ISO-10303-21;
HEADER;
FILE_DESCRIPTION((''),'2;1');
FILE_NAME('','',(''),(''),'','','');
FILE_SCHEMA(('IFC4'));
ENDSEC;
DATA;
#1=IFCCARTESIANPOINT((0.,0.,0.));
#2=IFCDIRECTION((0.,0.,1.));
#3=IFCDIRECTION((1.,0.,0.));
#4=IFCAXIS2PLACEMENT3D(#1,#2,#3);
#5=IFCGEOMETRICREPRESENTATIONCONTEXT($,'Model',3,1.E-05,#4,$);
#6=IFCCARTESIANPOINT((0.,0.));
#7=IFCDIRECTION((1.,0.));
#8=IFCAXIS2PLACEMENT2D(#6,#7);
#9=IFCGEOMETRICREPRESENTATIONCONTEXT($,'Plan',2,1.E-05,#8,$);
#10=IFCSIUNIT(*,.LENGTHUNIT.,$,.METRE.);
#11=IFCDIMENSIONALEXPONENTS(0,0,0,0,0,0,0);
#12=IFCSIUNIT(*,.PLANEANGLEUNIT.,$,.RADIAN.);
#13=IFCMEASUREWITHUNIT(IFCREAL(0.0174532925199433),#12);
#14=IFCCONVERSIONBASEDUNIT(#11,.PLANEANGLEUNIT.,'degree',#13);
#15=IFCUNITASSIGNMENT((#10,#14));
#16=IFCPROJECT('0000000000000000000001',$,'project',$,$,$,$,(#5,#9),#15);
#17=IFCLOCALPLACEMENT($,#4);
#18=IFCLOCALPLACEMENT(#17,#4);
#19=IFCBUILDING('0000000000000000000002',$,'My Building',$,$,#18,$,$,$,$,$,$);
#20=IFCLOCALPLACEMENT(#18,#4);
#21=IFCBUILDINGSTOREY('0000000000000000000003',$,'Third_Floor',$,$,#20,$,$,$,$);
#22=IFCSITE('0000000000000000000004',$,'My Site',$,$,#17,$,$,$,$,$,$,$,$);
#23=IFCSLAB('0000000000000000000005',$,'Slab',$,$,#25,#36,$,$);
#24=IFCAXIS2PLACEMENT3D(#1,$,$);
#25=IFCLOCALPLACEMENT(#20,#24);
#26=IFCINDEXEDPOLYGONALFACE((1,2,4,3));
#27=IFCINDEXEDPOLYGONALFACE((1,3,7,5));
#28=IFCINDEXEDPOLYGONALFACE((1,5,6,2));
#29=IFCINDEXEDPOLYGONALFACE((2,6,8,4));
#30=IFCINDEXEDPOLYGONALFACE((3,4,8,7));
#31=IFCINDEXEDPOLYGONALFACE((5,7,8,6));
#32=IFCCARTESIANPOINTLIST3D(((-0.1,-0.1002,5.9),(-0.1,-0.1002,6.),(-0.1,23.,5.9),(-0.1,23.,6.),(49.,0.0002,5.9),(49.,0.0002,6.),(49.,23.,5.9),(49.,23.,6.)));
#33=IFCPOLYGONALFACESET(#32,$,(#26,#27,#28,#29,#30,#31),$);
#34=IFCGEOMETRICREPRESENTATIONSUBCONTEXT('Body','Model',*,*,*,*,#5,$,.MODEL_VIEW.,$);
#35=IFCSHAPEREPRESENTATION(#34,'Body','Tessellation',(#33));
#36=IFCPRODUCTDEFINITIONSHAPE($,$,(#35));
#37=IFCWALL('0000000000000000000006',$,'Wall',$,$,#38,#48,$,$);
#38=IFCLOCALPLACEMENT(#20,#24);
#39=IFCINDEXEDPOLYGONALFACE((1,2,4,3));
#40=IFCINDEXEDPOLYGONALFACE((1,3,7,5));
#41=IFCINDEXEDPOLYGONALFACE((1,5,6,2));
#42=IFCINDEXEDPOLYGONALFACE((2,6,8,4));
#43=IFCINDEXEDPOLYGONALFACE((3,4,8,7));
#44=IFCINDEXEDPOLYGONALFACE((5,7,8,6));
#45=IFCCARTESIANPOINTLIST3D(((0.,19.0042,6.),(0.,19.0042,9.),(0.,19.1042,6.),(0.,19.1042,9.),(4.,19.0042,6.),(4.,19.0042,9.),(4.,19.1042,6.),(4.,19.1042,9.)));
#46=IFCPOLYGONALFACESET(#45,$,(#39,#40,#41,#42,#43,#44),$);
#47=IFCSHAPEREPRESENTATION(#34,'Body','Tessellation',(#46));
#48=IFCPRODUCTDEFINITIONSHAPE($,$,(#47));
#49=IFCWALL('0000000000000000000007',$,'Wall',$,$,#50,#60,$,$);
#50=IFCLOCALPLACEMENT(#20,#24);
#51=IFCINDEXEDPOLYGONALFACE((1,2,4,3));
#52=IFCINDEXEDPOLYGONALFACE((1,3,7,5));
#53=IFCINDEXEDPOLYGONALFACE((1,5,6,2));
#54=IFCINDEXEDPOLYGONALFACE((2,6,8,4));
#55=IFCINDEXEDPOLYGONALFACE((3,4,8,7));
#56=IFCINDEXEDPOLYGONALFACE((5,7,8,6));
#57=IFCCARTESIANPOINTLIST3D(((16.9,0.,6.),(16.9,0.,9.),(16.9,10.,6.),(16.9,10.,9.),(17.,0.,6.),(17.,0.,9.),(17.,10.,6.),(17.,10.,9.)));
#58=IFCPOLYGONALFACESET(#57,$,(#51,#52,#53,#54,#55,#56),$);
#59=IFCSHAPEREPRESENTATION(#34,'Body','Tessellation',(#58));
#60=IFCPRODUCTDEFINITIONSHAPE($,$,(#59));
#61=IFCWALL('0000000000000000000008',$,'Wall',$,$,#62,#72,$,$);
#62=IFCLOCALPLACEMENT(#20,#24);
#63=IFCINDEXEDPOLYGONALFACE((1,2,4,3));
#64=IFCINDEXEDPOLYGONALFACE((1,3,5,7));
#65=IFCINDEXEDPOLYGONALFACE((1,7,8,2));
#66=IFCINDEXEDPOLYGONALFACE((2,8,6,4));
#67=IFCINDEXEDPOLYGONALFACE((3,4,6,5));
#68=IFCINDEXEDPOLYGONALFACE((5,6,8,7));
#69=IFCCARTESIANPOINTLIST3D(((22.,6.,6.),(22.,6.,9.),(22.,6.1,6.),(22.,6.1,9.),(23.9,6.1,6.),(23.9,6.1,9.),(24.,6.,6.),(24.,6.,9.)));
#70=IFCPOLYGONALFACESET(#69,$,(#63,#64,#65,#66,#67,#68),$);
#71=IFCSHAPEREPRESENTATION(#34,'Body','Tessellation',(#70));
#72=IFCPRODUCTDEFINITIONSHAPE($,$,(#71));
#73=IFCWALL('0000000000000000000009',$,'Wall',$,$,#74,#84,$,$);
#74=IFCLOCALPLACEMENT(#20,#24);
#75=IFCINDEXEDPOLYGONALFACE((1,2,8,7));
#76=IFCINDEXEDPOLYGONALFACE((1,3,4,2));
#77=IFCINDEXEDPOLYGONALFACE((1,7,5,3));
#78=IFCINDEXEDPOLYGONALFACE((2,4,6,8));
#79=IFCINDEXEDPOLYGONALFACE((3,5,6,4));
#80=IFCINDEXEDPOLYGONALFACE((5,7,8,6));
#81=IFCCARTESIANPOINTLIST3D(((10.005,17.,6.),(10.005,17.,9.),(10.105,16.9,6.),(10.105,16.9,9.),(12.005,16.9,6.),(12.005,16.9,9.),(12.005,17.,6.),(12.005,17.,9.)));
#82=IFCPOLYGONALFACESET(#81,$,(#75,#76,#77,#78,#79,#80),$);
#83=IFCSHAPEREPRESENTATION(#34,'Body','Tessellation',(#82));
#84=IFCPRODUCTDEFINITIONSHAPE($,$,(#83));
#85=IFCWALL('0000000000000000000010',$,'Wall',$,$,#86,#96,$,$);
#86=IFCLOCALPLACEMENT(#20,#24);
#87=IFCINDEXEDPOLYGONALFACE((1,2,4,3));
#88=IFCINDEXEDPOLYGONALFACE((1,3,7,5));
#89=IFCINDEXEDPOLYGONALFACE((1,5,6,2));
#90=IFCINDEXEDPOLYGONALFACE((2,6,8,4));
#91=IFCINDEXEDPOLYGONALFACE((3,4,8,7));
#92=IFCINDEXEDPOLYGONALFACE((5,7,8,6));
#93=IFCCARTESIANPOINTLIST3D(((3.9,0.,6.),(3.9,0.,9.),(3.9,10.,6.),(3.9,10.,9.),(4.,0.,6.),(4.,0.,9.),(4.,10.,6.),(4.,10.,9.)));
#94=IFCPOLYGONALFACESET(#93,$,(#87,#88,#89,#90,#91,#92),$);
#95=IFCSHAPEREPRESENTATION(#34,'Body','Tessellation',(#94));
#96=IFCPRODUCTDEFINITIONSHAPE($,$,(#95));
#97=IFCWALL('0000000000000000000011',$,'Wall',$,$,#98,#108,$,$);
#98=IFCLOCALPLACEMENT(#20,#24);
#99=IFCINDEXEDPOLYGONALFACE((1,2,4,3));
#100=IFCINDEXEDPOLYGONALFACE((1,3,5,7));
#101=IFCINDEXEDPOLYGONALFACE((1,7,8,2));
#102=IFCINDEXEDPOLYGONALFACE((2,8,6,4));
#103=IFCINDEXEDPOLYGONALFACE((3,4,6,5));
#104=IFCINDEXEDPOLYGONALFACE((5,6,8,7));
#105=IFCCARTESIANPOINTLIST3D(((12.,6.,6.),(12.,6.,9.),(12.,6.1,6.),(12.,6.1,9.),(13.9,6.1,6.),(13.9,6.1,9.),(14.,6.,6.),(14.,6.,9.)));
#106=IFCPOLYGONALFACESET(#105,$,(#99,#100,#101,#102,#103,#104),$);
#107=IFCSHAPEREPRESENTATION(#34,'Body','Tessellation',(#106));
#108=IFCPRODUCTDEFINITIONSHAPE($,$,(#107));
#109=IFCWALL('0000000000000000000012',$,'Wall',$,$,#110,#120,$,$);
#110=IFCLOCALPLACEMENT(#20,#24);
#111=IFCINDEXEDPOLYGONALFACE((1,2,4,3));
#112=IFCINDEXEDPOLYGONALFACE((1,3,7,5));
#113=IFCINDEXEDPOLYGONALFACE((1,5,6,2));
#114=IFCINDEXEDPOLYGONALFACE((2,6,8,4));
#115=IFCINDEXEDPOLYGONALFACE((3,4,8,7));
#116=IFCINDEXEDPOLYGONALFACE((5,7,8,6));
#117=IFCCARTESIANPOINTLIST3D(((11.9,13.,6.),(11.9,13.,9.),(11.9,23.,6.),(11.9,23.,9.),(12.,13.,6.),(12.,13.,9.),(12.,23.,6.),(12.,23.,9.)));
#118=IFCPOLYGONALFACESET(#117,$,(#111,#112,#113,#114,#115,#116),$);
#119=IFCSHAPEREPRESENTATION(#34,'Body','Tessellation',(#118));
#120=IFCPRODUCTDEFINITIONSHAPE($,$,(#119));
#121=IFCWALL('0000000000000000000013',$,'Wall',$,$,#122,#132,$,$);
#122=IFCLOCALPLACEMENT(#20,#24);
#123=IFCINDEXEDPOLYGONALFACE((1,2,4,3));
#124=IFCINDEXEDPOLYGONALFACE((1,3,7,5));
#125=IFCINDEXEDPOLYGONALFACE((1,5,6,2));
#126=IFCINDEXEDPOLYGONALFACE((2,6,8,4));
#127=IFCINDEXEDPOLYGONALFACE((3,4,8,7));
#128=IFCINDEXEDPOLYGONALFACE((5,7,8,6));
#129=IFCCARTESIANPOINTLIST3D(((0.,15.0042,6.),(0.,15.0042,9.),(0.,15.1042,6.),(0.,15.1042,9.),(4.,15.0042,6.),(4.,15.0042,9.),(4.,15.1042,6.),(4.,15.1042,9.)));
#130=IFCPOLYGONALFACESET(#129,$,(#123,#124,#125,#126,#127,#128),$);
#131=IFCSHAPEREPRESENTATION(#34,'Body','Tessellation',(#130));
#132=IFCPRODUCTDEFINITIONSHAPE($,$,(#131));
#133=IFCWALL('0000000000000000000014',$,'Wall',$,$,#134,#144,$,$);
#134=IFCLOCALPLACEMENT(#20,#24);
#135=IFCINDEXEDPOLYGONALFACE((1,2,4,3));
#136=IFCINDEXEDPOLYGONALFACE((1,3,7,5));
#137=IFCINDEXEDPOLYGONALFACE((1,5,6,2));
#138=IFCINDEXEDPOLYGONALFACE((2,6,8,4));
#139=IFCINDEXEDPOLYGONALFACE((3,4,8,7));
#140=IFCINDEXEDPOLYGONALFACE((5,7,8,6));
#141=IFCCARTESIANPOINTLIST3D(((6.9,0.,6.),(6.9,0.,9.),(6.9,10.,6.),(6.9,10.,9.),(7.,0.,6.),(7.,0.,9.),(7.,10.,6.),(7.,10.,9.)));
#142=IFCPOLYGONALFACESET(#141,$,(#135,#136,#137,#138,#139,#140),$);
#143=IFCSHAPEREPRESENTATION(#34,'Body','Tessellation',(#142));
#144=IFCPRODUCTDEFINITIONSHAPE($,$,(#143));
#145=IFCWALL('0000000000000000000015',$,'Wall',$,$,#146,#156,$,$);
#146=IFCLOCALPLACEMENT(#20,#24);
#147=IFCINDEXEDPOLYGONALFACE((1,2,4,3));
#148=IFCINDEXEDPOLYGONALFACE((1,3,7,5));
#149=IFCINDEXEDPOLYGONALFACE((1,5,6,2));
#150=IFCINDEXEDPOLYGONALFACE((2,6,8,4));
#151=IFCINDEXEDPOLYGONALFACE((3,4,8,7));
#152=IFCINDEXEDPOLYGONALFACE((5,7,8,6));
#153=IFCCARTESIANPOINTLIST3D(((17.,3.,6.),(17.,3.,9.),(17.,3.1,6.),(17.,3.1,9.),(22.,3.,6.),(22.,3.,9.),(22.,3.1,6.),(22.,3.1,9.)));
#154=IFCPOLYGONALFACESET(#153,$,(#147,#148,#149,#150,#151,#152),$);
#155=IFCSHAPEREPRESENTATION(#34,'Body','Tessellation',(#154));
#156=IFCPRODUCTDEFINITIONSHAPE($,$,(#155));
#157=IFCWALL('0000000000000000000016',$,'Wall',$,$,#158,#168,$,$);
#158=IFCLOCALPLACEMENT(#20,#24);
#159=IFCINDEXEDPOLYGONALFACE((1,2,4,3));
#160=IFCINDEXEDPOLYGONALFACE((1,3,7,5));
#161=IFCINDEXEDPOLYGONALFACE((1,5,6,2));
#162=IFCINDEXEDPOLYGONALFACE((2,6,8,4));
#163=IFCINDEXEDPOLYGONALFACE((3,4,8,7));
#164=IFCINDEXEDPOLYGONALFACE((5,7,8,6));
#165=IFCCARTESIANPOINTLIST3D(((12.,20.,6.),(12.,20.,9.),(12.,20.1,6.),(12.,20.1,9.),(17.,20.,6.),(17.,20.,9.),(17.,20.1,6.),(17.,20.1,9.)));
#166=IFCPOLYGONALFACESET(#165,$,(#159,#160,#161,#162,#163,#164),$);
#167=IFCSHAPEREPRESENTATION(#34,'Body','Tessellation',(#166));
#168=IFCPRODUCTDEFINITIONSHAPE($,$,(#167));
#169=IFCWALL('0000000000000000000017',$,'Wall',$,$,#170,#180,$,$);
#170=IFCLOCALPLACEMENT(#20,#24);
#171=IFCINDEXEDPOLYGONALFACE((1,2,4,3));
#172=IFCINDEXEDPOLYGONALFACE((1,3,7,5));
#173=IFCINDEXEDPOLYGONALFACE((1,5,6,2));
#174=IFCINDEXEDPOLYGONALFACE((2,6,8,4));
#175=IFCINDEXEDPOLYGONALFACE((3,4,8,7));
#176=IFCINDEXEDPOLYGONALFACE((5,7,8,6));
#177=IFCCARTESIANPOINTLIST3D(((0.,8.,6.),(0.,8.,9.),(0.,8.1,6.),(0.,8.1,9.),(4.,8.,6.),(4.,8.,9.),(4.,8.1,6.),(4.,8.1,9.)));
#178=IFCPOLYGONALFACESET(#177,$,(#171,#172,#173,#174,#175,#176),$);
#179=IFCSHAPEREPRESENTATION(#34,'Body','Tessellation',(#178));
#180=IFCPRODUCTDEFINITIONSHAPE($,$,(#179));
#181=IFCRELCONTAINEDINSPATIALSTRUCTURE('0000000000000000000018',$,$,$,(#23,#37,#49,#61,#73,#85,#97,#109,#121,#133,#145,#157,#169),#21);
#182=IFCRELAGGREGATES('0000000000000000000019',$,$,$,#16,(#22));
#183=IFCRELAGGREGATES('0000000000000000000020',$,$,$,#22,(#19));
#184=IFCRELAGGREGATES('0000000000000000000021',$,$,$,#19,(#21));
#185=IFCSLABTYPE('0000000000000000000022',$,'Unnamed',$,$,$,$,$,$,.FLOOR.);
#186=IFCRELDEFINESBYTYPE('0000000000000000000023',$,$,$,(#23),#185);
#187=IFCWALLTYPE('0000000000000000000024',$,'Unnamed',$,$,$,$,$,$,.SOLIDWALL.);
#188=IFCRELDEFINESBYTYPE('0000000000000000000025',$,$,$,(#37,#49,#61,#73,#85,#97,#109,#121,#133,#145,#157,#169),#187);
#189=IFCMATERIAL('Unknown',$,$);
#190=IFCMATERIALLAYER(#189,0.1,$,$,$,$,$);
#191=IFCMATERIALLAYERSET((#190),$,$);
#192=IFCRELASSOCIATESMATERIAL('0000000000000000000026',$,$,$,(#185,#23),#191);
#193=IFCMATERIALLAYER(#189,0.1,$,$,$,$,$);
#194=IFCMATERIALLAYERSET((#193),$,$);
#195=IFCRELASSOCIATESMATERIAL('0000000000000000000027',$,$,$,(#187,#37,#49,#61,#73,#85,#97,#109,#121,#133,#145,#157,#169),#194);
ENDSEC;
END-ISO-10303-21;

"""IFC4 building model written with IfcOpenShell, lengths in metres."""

from ifc_helpers import new_model, entity, si_unit, converted_unit, frame, origin_with_axes, origin_2d_with_axis, place, context, subcontext, project, spatial, line, indexed_curve, outline, extrude, material, layer, layer_set, layer_usage, type_object, element, save


model = new_model("IFC4")

# Units and contexts
model_context = context("Model", 3, precision=1e-05, world=origin_with_axes())
plan_context = context("Plan", 2, precision=1e-05, world=origin_2d_with_axis())
body_context = subcontext(model_context, "Body", "Model", "MODEL_VIEW")
ifc_project = project(units=[si_unit("LENGTHUNIT", "METRE"), converted_unit("PLANEANGLEUNIT", "degree", entity("IfcReal", 0.0174532925199433), si_unit("PLANEANGLEUNIT", "RADIAN"), dimensions=[0, 0, 0, 0, 0, 0, 0])], contexts=[model_context, plan_context])

# Site, building, storey
site_placement = place(None, origin_with_axes())
site = spatial("IfcSite", under=ifc_project, at=site_placement, Name="My Site")
building_placement = place(site_placement, origin_with_axes())
building = spatial("IfcBuilding", under=site, at=building_placement, Name="My Building")
storey_placement = place(building_placement, origin_with_axes())
storey = spatial("IfcBuildingStorey", under=building, at=storey_placement, Name="Third_Floor")

# Slab
ifc_material = material(Name="Unknown")
ifc_layer_1 = layer(ifc_material, 0.1)
ifc_layer_set_1 = layer_set([ifc_layer_1])
ifc_layer_usage_1 = layer_usage(ifc_layer_set_1, "AXIS3", "POSITIVE", -0.1)
slab_type = type_object("IfcSlabType", Name="Unnamed", PredefinedType="FLOOR", material=ifc_layer_set_1)
slab_placement = place(storey_placement, frame((-0.1, 23.0, 6.0), z_axis=(0.0, 0.0, 1.0), x_axis=(1.0, 0.0, 0.0)))
element("IfcSlab", 1, at=slab_placement, inside=storey, type_object=slab_type, material=ifc_layer_usage_1, Name="Slab", context=body_context, shape_type="SweptSolid", body=[
    extrude(outline(indexed_curve([(0.0, -23.1002), (49.1, -22.9998), (49.1, 0.0), (0.0, 0.0), (0.0, -23.1002)])), frame((0.0, 0.0, -0.1), z_axis=(0.0, 0.0, 1.0), x_axis=(1.0, 0.0, 0.0)), (0.0, 0.0, 1.0), 0.1),
])

# Walls
ifc_layer_2 = layer(ifc_material, 0.1)
ifc_layer_set_2 = layer_set([ifc_layer_2])
ifc_layer_usage_2 = layer_usage(ifc_layer_set_2, "AXIS2", "POSITIVE", 0.0)
wall_type = type_object("IfcWallType", Name="Unnamed", PredefinedType="SOLIDWALL", material=ifc_layer_set_2)
wall_1_placement = place(storey_placement, frame((0.0, 19.0042, 6.0), z_axis=(0.0, 0.0, 1.0), x_axis=(1.0, 0.0, 0.0)))
element("IfcWall", 2, at=wall_1_placement, inside=storey, type_object=wall_type, material=ifc_layer_usage_2, Name="Wall", context=body_context, shape_type="SweptSolid", body=[
    extrude(outline(indexed_curve([(0.0, 0.0), (0.0, 0.1), (4.0, 0.1), (4.0, 0.0)], segments=[line(1, 2, 3, 4, 1)])), origin_with_axes(), (0.0, 0.0, 1.0), 3.0),
])
ifc_layer_usage_3 = layer_usage(ifc_layer_set_2, "AXIS2", "POSITIVE", 0.0)
wall_2_placement = place(storey_placement, frame((16.9, 10.0, 6.0), z_axis=(0.0, 0.0, 1.0), x_axis=(0.0, -1.0, 0.0)))
element("IfcWall", 3, at=wall_2_placement, inside=storey, type_object=wall_type, material=ifc_layer_usage_3, Name="Wall", context=body_context, shape_type="SweptSolid", body=[
    extrude(outline(indexed_curve([(0.0, 0.0), (0.0, 0.1), (10.0, 0.1), (10.0, 0.0)], segments=[line(1, 2, 3, 4, 1)])), origin_with_axes(), (0.0, 0.0, 1.0), 3.0),
])
ifc_layer_usage_4 = layer_usage(ifc_layer_set_2, "AXIS2", "POSITIVE", 0.0)
wall_3_placement = place(storey_placement, frame((22.0, 6.0, 6.0), z_axis=(0.0, 0.0, 1.0), x_axis=(1.0, 0.0, 0.0)))
element("IfcWall", 4, at=wall_3_placement, inside=storey, type_object=wall_type, material=ifc_layer_usage_4, Name="Wall", context=body_context, shape_type="SweptSolid", body=[
    extrude(outline(indexed_curve([(0.0, 0.0), (0.0, 0.1), (1.9, 0.1), (2.0, 0.0)], segments=[line(1, 2, 3, 4, 1)])), origin_with_axes(), (0.0, 0.0, 1.0), 3.0),
])
ifc_layer_usage_5 = layer_usage(ifc_layer_set_2, "AXIS2", "POSITIVE", 0.0)
wall_4_placement = place(storey_placement, frame((12.005, 17.0, 6.0), z_axis=(0.0, 0.0, 1.0), x_axis=(-1.0, 0.0, 0.0)))
element("IfcWall", 5, at=wall_4_placement, inside=storey, type_object=wall_type, material=ifc_layer_usage_5, Name="Wall", context=body_context, shape_type="SweptSolid", body=[
    extrude(outline(indexed_curve([(0.0, 0.0), (0.0, 0.1), (1.9, 0.1), (2.0, 0.0)], segments=[line(1, 2, 3, 4, 1)])), origin_with_axes(), (0.0, 0.0, 1.0), 3.0),
])
ifc_layer_usage_6 = layer_usage(ifc_layer_set_2, "AXIS2", "POSITIVE", 0.0)
wall_5_placement = place(storey_placement, frame((3.9, 10.0, 6.0), z_axis=(0.0, 0.0, 1.0), x_axis=(0.0, -1.0, 0.0)))
element("IfcWall", 6, at=wall_5_placement, inside=storey, type_object=wall_type, material=ifc_layer_usage_6, Name="Wall", context=body_context, shape_type="SweptSolid", body=[
    extrude(outline(indexed_curve([(0.0, 0.0), (0.0, 0.1), (10.0, 0.1), (10.0, 0.0)], segments=[line(1, 2, 3, 4, 1)])), origin_with_axes(), (0.0, 0.0, 1.0), 3.0),
])
ifc_layer_usage_7 = layer_usage(ifc_layer_set_2, "AXIS2", "POSITIVE", 0.0)
wall_6_placement = place(storey_placement, frame((12.0, 6.0, 6.0), z_axis=(0.0, 0.0, 1.0), x_axis=(1.0, 0.0, 0.0)))
element("IfcWall", 7, at=wall_6_placement, inside=storey, type_object=wall_type, material=ifc_layer_usage_7, Name="Wall", context=body_context, shape_type="SweptSolid", body=[
    extrude(outline(indexed_curve([(0.0, 0.0), (0.0, 0.1), (1.9, 0.1), (2.0, 0.0)], segments=[line(1, 2, 3, 4, 1)])), origin_with_axes(), (0.0, 0.0, 1.0), 3.0),
])
ifc_layer_usage_8 = layer_usage(ifc_layer_set_2, "AXIS2", "POSITIVE", 0.0)
wall_7_placement = place(storey_placement, frame((11.9, 23.0, 6.0), z_axis=(0.0, 0.0, 1.0), x_axis=(0.0, -1.0, 0.0)))
element("IfcWall", 8, at=wall_7_placement, inside=storey, type_object=wall_type, material=ifc_layer_usage_8, Name="Wall", context=body_context, shape_type="SweptSolid", body=[
    extrude(outline(indexed_curve([(0.0, 0.0), (0.0, 0.1), (10.0, 0.1), (10.0, 0.0)], segments=[line(1, 2, 3, 4, 1)])), origin_with_axes(), (0.0, 0.0, 1.0), 3.0),
])
ifc_layer_usage_9 = layer_usage(ifc_layer_set_2, "AXIS2", "POSITIVE", 0.0)
wall_8_placement = place(storey_placement, frame((0.0, 15.0042, 6.0), z_axis=(0.0, 0.0, 1.0), x_axis=(1.0, 0.0, 0.0)))
element("IfcWall", 9, at=wall_8_placement, inside=storey, type_object=wall_type, material=ifc_layer_usage_9, Name="Wall", context=body_context, shape_type="SweptSolid", body=[
    extrude(outline(indexed_curve([(0.0, 0.0), (0.0, 0.1), (4.0, 0.1), (4.0, 0.0)], segments=[line(1, 2, 3, 4, 1)])), origin_with_axes(), (0.0, 0.0, 1.0), 3.0),
])
ifc_layer_usage_10 = layer_usage(ifc_layer_set_2, "AXIS2", "POSITIVE", 0.0)
wall_9_placement = place(storey_placement, frame((6.9, 10.0, 6.0), z_axis=(0.0, 0.0, 1.0), x_axis=(0.0, -1.0, 0.0)))
element("IfcWall", 10, at=wall_9_placement, inside=storey, type_object=wall_type, material=ifc_layer_usage_10, Name="Wall", context=body_context, shape_type="SweptSolid", body=[
    extrude(outline(indexed_curve([(0.0, 0.0), (0.0, 0.1), (10.0, 0.1), (10.0, 0.0)], segments=[line(1, 2, 3, 4, 1)])), origin_with_axes(), (0.0, 0.0, 1.0), 3.0),
])
ifc_layer_usage_11 = layer_usage(ifc_layer_set_2, "AXIS2", "POSITIVE", 0.0)
wall_10_placement = place(storey_placement, frame((17.0, 3.0, 6.0), z_axis=(0.0, 0.0, 1.0), x_axis=(1.0, 0.0, 0.0)))
element("IfcWall", 11, at=wall_10_placement, inside=storey, type_object=wall_type, material=ifc_layer_usage_11, Name="Wall", context=body_context, shape_type="SweptSolid", body=[
    extrude(outline(indexed_curve([(0.0, 0.0), (0.0, 0.1), (5.0, 0.1), (5.0, 0.0)], segments=[line(1, 2, 3, 4, 1)])), origin_with_axes(), (0.0, 0.0, 1.0), 3.0),
])
ifc_layer_usage_12 = layer_usage(ifc_layer_set_2, "AXIS2", "POSITIVE", 0.0)
wall_11_placement = place(storey_placement, frame((12.0, 20.0, 6.0), z_axis=(0.0, 0.0, 1.0), x_axis=(1.0, 0.0, 0.0)))
element("IfcWall", 12, at=wall_11_placement, inside=storey, type_object=wall_type, material=ifc_layer_usage_12, Name="Wall", context=body_context, shape_type="SweptSolid", body=[
    extrude(outline(indexed_curve([(0.0, 0.0), (0.0, 0.1), (5.0, 0.1), (5.0, 0.0)], segments=[line(1, 2, 3, 4, 1)])), origin_with_axes(), (0.0, 0.0, 1.0), 3.0),
])
ifc_layer_usage_13 = layer_usage(ifc_layer_set_2, "AXIS2", "POSITIVE", 0.0)
wall_12_placement = place(storey_placement, frame((0.0, 8.0, 6.0), z_axis=(0.0, 0.0, 1.0), x_axis=(1.0, 0.0, 0.0)))
element("IfcWall", 13, at=wall_12_placement, inside=storey, type_object=wall_type, material=ifc_layer_usage_13, Name="Wall", context=body_context, shape_type="SweptSolid", body=[
    extrude(outline(indexed_curve([(0.0, 0.0), (0.0, 0.1), (4.0, 0.1), (4.0, 0.0)], segments=[line(1, 2, 3, 4, 1)])), origin_with_axes(), (0.0, 0.0, 1.0), 3.0),
])

save(model, "model.ifc")
